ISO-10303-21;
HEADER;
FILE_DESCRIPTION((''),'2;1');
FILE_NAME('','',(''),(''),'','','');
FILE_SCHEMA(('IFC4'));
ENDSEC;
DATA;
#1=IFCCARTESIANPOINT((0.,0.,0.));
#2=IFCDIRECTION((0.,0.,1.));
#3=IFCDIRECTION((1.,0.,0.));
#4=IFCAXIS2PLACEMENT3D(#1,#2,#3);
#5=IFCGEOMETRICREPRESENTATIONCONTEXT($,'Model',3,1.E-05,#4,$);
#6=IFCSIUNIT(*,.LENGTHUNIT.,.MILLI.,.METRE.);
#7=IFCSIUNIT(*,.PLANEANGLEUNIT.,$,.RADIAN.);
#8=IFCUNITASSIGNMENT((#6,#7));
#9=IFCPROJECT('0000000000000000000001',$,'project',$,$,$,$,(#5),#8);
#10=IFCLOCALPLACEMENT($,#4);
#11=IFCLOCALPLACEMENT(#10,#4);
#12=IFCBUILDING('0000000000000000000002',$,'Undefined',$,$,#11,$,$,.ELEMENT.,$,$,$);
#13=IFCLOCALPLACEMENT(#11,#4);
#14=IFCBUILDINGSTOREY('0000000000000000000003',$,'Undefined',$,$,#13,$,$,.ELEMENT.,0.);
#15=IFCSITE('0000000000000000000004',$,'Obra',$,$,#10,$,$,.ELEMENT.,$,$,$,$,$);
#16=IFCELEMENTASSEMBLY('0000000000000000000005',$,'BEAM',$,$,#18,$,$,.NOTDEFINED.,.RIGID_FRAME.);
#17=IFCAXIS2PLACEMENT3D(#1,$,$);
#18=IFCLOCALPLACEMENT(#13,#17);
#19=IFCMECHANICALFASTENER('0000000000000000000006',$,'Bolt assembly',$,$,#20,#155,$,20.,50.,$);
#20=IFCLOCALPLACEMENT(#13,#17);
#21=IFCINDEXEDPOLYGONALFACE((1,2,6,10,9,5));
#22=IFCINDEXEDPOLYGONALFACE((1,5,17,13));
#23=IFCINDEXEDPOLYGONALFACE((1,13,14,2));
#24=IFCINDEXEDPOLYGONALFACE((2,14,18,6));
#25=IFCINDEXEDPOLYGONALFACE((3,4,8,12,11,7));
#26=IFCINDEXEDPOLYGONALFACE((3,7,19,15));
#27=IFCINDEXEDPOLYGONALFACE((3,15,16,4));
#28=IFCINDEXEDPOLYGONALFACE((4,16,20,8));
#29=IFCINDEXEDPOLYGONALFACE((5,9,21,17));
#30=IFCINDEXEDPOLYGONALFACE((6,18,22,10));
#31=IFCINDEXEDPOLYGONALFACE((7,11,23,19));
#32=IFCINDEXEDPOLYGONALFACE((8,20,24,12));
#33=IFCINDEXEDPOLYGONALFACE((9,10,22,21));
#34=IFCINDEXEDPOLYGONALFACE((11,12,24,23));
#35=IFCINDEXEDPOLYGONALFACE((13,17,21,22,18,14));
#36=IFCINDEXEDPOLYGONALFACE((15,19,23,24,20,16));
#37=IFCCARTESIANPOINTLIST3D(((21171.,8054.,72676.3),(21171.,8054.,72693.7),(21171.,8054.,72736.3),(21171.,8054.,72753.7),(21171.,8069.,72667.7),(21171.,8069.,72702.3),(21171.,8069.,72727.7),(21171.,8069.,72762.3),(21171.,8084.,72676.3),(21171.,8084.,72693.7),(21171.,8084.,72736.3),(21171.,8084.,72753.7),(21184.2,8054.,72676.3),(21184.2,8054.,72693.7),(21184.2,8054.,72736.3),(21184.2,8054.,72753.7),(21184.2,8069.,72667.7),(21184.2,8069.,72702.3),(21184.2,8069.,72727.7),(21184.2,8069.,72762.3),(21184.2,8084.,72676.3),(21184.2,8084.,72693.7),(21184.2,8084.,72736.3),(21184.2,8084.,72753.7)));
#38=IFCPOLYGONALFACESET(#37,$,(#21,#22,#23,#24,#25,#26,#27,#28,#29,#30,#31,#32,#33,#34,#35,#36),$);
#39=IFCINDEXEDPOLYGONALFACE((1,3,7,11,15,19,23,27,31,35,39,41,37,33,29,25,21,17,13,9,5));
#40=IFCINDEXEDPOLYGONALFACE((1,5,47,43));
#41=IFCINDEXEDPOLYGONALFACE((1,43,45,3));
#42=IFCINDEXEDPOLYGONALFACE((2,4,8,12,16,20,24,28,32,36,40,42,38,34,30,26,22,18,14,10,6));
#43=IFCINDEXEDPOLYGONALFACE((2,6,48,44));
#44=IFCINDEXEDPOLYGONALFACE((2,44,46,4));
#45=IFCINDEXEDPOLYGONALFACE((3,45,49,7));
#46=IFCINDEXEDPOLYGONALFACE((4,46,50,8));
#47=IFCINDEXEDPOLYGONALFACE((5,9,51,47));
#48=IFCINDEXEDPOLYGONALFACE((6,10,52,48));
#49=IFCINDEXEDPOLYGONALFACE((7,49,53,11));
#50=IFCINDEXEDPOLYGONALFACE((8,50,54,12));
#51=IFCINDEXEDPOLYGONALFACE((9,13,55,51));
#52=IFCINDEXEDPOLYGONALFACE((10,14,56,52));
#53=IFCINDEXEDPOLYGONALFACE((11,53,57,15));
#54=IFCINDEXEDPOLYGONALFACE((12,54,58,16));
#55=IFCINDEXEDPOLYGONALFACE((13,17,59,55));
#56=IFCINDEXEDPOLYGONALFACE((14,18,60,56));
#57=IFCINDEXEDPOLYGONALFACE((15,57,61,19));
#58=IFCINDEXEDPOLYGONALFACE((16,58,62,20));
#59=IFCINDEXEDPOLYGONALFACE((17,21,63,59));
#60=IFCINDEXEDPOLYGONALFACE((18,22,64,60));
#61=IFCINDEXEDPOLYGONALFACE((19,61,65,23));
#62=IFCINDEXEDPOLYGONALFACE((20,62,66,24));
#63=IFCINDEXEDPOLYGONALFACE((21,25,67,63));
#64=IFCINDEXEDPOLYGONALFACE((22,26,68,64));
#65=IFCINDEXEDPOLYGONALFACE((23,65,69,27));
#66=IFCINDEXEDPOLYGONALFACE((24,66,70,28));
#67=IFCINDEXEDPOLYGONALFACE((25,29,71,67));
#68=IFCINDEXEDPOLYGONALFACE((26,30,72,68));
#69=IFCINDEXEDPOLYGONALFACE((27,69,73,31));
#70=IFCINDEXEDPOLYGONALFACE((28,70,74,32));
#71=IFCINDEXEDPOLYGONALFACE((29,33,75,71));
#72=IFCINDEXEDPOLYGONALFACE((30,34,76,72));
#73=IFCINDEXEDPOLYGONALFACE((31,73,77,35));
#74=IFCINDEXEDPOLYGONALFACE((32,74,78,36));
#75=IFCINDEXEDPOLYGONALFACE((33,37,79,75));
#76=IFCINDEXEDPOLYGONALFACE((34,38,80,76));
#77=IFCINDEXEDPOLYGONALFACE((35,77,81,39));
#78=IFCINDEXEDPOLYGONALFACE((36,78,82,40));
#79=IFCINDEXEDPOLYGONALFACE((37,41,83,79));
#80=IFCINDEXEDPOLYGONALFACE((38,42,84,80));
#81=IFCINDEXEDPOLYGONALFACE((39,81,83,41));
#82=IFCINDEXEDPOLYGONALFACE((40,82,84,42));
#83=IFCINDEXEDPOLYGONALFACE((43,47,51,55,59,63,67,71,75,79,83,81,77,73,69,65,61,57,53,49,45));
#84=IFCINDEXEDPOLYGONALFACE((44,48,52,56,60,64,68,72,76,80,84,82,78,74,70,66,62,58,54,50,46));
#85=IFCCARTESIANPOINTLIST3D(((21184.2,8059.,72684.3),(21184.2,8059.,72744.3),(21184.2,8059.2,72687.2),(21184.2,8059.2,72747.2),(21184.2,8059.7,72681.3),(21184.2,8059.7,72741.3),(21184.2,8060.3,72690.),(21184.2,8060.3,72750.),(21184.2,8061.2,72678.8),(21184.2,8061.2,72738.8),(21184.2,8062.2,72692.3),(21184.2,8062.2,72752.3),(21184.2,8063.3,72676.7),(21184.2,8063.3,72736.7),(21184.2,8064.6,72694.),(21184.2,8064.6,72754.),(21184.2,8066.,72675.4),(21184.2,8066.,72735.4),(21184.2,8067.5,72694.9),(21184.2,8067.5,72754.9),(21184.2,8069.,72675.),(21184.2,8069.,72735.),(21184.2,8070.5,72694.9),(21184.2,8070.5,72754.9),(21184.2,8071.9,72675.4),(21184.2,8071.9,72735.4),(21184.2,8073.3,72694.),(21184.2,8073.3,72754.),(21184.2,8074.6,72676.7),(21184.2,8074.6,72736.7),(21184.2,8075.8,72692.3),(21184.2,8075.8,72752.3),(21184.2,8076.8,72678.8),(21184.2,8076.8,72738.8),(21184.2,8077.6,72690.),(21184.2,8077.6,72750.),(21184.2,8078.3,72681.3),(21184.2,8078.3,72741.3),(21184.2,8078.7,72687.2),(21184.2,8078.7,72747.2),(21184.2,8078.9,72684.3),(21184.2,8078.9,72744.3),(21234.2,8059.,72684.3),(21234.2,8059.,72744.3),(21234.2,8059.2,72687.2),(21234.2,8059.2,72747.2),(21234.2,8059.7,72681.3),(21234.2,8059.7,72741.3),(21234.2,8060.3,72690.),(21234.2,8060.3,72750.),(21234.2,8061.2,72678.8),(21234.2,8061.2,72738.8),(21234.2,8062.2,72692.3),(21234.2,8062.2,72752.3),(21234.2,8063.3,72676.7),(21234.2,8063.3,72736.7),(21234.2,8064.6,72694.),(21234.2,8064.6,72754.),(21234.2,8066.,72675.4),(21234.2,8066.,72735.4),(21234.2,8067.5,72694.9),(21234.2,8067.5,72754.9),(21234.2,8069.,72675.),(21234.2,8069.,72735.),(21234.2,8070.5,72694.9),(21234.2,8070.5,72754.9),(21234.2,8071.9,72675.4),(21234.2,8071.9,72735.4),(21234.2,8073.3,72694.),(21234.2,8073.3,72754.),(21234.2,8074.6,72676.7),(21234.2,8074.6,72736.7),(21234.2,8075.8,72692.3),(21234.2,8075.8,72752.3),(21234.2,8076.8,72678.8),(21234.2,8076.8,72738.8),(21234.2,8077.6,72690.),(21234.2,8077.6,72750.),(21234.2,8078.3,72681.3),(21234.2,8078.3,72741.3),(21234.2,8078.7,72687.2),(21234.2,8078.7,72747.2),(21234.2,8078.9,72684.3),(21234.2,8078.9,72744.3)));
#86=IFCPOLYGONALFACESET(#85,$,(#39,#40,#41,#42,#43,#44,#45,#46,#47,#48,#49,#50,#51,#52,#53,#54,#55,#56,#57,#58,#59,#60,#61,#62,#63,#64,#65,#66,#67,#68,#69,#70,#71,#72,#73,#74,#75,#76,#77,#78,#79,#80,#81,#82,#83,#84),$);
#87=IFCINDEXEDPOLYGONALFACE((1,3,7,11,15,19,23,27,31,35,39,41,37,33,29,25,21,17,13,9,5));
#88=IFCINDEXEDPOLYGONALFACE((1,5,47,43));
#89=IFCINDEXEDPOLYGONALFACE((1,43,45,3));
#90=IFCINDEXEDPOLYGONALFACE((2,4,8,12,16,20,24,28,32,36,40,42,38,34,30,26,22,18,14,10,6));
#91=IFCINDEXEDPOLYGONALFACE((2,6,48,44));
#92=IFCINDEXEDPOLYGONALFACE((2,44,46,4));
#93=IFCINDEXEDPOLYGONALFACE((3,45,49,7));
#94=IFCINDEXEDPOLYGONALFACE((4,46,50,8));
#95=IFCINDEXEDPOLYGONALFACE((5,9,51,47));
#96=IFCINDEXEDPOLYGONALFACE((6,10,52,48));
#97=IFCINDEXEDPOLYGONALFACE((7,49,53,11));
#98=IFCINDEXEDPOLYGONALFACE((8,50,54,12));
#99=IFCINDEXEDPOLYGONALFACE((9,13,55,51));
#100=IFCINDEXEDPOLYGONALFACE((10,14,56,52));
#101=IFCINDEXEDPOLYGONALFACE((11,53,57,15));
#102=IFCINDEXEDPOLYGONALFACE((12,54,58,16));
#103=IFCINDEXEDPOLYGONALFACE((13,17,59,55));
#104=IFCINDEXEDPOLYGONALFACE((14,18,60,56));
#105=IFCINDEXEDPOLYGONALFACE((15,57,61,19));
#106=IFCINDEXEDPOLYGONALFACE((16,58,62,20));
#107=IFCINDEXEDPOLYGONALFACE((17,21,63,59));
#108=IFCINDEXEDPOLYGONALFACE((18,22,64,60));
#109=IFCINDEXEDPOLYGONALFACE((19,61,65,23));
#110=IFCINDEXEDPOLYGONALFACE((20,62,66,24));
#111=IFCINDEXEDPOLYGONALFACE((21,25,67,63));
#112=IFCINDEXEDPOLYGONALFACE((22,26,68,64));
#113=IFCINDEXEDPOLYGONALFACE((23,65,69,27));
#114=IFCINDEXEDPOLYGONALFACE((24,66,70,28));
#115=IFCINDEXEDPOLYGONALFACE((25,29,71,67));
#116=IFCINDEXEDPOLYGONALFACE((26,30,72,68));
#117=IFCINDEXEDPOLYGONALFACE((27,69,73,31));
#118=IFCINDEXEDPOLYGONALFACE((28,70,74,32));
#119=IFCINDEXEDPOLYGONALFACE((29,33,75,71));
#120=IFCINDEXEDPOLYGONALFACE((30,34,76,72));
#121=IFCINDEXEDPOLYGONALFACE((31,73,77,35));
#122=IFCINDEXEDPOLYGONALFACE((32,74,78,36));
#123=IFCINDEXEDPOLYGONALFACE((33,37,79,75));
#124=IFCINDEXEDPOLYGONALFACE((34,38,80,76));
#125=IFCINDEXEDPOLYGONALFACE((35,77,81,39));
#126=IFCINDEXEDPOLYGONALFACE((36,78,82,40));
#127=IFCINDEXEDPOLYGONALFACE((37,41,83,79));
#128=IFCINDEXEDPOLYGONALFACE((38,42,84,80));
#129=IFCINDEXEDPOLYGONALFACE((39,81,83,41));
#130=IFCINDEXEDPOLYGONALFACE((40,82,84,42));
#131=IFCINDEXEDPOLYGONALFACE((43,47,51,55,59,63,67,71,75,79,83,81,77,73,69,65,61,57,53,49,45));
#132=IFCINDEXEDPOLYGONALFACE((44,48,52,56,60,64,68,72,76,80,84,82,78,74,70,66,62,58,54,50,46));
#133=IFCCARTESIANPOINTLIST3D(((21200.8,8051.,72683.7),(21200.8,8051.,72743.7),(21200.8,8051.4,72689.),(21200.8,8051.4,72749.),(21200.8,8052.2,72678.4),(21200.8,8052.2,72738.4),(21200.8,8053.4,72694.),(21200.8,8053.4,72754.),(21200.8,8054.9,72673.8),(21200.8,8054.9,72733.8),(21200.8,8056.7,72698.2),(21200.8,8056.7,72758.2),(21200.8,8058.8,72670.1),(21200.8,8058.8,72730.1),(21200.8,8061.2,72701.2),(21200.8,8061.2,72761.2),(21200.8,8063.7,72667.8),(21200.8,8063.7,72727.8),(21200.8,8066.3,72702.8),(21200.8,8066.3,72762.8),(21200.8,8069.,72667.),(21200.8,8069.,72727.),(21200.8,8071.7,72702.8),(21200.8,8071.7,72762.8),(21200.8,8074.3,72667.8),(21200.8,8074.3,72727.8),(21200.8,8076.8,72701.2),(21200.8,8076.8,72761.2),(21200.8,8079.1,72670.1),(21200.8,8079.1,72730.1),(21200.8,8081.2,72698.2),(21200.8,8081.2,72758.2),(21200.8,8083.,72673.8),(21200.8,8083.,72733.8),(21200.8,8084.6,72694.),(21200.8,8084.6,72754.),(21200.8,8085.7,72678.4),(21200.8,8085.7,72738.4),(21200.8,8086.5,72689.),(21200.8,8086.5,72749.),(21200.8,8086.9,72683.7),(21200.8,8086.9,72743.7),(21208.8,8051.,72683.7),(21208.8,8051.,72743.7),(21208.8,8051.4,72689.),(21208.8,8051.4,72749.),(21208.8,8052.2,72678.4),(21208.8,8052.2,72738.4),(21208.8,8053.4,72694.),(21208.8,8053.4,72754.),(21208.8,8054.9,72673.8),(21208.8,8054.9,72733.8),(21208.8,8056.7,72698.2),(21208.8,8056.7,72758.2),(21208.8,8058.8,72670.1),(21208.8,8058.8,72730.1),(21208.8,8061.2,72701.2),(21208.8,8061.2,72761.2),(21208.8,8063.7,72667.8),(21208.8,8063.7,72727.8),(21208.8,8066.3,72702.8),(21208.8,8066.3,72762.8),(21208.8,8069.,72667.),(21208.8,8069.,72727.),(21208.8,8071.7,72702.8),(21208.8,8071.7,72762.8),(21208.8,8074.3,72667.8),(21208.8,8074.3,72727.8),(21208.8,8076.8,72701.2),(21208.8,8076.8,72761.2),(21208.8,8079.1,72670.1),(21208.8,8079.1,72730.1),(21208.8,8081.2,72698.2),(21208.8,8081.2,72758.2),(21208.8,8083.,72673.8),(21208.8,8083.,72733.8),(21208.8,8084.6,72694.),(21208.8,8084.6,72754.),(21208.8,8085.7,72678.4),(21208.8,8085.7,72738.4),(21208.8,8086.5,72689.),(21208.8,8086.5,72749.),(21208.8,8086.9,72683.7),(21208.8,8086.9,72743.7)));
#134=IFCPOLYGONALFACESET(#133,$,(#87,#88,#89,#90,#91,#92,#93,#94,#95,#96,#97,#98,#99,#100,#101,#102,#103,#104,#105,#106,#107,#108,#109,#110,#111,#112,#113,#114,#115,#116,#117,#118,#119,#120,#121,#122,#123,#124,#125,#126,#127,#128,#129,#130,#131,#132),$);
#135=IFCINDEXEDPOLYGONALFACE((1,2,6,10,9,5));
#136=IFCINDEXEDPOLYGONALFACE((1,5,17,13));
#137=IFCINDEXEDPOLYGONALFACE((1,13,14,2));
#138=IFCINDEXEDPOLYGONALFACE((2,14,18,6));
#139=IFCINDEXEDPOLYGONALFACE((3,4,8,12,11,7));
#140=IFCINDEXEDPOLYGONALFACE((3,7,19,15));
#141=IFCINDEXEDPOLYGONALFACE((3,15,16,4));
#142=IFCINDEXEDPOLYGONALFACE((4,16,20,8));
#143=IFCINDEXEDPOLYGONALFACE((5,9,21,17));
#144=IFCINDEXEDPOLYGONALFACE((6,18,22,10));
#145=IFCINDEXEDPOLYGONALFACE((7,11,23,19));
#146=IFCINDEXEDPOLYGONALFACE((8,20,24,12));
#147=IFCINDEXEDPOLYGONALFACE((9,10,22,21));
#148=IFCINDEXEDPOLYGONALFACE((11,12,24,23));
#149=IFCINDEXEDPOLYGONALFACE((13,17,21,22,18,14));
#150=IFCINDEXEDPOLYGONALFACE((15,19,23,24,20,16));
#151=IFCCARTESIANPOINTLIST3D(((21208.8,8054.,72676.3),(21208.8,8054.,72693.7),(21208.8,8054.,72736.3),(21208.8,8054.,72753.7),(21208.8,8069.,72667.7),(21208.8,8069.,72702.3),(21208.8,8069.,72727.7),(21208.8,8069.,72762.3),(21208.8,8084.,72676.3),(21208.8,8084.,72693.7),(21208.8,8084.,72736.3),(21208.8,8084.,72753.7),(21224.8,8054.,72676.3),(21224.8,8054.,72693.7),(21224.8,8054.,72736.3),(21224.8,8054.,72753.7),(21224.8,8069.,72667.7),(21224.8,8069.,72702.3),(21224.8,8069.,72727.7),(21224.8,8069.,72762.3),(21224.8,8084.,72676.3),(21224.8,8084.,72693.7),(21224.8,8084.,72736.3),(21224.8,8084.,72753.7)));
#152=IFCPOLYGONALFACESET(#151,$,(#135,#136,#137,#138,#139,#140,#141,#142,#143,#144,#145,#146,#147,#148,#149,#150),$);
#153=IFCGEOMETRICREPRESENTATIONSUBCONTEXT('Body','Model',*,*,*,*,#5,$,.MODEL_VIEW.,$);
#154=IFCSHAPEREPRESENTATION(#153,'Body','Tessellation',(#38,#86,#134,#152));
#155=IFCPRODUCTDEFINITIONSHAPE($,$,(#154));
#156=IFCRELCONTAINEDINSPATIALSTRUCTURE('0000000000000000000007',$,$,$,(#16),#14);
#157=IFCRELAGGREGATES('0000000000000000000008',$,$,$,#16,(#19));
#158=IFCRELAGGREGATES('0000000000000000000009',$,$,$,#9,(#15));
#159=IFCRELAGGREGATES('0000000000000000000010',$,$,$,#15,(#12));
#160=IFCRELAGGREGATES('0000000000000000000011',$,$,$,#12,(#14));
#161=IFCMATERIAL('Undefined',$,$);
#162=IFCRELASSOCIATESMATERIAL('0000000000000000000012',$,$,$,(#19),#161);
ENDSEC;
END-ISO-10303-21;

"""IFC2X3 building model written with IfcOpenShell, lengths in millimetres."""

from ifc_helpers import new_model, si_unit, frame, origin_with_axes, origin_2d_with_axis, place, context, subcontext, project, spatial, polyline, circle, outline, extrude, source, transform, mapped, material, element, aggregate, save


model = new_model("IFC2X3")

# Units and contexts
model_context = context("Model", 3, precision=1e-05, world=origin_with_axes())
body_context = subcontext(model_context, "Body", "Model", "MODEL_VIEW")
ifc_project = project(units=[si_unit("LENGTHUNIT", "METRE", prefix="MILLI"), si_unit("PLANEANGLEUNIT", "RADIAN")], contexts=[model_context])

# Site, building, storey
site_placement = place(None, origin_with_axes())
site = spatial("IfcSite", under=ifc_project, at=site_placement, Name="Obra", CompositionType="ELEMENT")
building_placement = place(site_placement, origin_with_axes())
building = spatial("IfcBuilding", under=site, at=building_placement, Name="Undefined", CompositionType="ELEMENT")
storey_placement = place(building_placement, origin_with_axes())
storey = spatial("IfcBuildingStorey", under=building, at=storey_placement, Name="Undefined", CompositionType="ELEMENT", Elevation=0.0)

# Shared definitions
ifc_material = material(Name="Undefined")

# Shared definitions
shared_shape_1 = source(origin_with_axes(), body_context, "Body", "SweptSolid", [
    extrude(outline(polyline([(17.3, 0.0), (8.7, 15.0), (-8.7, 15.0), (-17.3, 0.0), (-8.7, -15.0), (8.7, -15.0), (17.3, 0.0)])), frame((0.0, -26.5, 0.0), z_axis=(0.0, 1.0, 0.0), x_axis=(1.0, 0.0, 0.0)), (0.0, 0.0, 1.0), 13.2),
    extrude(circle(Radius=10.0, at=origin_2d_with_axis()), frame((0.0, -13.3, 0.0), z_axis=(0.0, 1.0, 0.0), x_axis=(1.0, 0.0, 0.0)), (0.0, 0.0, 1.0), 50.0),
    extrude(circle(Radius=18.0, at=origin_2d_with_axis()), frame((0.0, 3.3, 0.0), z_axis=(0.0, 1.0, 0.0), x_axis=(1.0, 0.0, 0.0)), (0.0, 0.0, 1.0), 8.0),
    extrude(outline(polyline([(17.3, 0.0), (8.7, 15.0), (-8.7, 15.0), (-17.3, 0.0), (-8.7, -15.0), (8.7, -15.0), (17.3, 0.0)])), frame((0.0, 11.3, 0.0), z_axis=(0.0, 1.0, 0.0), x_axis=(1.0, 0.0, 0.0)), (0.0, 0.0, 1.0), 16.0),
])

# Element assembly, mechanical fastener
assembly_1_placement = place(storey_placement, origin_with_axes())
assembly_1 = element("IfcElementAssembly", 1, at=assembly_1_placement, inside=storey, Name="BEAM", AssemblyPlace="NOTDEFINED", PredefinedType="RIGID_FRAME")
mechanical_fastener_1_placement = place(assembly_1_placement, frame((21197.5, 8109.0, 72850.0), z_axis=(0.0, -1.0, 0.0), x_axis=(0.0, 0.0, -1.0)))
mechanical_fastener_1 = element("IfcMechanicalFastener", 2, at=mechanical_fastener_1_placement, material=ifc_material, Name="Bolt assembly", NominalDiameter=20.0, NominalLength=50.0, context=body_context, shape_type="MappedRepresentation", body=[
    mapped(shared_shape_1, transform((105.0, 0.0, 40.0))),
    mapped(shared_shape_1, transform((165.0, 0.0, 40.0))),
])
aggregate(assembly_1, [mechanical_fastener_1])

save(model, "model.ifc")
